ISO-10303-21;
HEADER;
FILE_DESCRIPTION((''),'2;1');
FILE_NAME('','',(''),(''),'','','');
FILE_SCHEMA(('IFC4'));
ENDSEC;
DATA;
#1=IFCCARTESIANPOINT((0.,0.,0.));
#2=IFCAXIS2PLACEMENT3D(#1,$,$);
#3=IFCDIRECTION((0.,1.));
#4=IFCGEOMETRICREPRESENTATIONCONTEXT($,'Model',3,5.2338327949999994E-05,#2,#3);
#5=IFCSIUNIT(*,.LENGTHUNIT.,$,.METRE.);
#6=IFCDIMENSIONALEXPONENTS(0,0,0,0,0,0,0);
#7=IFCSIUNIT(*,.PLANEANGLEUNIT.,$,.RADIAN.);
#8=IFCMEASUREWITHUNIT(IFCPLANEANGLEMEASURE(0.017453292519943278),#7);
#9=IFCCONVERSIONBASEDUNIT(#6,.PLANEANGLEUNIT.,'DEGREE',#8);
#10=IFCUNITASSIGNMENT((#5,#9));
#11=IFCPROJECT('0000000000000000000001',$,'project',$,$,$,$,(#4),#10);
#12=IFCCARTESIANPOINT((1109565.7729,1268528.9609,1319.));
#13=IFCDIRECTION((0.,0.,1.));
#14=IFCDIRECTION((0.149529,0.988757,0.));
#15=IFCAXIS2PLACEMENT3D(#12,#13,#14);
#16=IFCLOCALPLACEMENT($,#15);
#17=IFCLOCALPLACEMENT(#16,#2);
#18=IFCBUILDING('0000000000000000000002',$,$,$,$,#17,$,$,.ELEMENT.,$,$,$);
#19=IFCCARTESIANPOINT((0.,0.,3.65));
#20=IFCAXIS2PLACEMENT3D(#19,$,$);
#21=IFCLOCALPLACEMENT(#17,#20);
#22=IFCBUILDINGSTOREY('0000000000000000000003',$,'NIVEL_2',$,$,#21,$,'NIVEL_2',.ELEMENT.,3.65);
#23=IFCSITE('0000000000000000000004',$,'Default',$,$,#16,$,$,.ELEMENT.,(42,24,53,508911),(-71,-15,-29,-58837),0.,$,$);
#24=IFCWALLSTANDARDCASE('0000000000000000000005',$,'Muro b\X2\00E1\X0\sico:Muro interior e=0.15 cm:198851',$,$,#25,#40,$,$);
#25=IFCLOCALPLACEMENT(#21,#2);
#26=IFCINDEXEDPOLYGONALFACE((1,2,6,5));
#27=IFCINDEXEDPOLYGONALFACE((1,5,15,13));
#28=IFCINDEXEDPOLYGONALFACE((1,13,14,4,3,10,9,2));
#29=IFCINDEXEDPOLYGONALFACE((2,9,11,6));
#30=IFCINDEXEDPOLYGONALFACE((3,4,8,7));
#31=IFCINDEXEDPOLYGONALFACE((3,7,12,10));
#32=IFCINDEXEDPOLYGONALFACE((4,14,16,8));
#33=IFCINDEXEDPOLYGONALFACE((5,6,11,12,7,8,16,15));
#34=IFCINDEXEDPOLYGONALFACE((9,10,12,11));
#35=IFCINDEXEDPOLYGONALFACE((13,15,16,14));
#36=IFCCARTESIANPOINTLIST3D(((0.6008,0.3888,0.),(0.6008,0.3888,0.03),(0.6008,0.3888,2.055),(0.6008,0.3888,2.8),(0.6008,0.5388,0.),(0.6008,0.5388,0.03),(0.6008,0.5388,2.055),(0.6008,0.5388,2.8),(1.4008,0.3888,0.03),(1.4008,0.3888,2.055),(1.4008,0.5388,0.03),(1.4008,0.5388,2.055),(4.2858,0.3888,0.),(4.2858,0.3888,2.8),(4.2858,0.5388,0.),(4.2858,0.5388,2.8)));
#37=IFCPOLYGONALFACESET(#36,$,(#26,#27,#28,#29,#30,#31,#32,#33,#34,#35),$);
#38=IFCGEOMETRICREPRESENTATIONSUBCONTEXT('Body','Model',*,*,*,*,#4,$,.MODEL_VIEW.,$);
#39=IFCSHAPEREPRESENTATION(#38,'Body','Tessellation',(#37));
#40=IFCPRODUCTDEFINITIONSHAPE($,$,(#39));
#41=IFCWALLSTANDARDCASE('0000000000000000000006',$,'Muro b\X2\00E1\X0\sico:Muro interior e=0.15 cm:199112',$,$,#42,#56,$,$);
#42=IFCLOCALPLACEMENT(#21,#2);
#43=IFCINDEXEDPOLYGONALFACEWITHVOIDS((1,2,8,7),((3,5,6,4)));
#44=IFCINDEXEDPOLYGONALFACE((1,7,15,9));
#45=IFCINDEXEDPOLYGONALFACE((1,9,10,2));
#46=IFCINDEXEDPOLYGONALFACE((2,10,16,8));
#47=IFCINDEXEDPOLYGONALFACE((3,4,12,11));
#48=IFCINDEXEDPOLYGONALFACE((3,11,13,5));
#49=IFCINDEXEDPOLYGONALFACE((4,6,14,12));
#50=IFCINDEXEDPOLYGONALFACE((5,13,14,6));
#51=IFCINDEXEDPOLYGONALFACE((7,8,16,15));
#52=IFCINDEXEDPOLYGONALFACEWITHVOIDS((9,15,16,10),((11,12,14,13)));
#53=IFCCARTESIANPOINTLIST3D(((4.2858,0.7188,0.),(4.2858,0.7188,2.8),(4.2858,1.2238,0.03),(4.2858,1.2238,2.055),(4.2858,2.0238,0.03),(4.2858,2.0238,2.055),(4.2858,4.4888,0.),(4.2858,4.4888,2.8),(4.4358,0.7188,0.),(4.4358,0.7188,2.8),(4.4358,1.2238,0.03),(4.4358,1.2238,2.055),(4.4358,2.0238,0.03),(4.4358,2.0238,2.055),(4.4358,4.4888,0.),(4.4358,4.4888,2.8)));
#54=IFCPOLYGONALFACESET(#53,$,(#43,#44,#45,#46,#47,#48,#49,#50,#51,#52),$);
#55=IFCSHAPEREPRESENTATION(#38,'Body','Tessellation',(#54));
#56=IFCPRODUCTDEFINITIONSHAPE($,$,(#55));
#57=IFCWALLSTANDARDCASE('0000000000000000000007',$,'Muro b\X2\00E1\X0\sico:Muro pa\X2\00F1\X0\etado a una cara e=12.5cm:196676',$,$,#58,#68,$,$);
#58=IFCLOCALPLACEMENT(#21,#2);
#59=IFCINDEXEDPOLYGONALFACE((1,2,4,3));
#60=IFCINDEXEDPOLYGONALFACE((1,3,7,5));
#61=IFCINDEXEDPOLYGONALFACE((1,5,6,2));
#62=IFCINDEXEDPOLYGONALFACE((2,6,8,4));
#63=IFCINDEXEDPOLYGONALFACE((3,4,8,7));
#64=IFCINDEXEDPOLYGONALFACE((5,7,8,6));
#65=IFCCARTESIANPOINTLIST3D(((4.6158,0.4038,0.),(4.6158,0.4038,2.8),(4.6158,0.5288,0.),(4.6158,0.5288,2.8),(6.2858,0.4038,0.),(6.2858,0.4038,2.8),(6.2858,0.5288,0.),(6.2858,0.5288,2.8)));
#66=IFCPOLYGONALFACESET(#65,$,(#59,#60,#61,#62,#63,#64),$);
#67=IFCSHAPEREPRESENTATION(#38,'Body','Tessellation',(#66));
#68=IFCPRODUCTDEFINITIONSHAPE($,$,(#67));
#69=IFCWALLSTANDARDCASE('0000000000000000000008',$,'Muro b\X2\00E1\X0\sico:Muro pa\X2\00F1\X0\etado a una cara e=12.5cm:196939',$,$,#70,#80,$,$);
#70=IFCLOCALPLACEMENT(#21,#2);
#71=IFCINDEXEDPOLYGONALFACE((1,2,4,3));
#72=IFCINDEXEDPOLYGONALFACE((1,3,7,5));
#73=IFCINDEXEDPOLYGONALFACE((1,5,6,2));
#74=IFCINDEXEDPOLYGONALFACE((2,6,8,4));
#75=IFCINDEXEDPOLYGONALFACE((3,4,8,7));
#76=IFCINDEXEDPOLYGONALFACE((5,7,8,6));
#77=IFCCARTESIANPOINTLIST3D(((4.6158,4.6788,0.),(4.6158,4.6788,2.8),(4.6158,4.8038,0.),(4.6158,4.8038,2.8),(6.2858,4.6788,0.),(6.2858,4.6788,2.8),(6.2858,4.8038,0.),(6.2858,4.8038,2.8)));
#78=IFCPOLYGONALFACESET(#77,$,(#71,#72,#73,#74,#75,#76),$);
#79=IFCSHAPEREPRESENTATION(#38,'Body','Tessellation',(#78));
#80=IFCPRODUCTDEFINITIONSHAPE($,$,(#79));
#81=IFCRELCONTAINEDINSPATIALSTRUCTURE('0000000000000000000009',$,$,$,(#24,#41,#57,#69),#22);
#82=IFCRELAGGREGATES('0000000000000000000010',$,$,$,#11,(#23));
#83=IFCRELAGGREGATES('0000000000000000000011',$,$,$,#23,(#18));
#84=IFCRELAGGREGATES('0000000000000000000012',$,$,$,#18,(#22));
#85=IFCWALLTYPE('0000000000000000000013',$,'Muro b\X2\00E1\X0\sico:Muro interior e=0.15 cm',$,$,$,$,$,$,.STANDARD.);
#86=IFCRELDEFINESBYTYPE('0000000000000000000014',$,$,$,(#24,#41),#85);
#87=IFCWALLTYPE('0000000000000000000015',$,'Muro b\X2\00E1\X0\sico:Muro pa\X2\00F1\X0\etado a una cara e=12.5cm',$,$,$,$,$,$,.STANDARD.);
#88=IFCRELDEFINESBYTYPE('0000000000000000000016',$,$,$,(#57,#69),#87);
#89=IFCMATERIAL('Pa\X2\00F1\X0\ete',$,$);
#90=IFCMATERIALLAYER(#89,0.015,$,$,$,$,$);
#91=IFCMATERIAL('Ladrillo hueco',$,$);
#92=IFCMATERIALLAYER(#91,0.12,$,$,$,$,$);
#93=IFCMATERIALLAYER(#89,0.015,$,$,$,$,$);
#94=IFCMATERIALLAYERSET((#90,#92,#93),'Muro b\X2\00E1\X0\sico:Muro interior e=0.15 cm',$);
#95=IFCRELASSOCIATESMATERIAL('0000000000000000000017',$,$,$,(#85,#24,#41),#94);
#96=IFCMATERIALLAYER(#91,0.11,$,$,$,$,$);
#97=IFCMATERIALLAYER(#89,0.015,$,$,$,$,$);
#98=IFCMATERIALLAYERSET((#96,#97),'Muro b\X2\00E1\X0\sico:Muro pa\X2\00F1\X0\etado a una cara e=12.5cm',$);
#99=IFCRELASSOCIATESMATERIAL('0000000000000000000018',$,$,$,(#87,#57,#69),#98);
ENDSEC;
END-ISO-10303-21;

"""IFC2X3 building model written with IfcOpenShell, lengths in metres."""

from ifc_helpers import new_model, entity, si_unit, converted_unit, direction, frame, frame_2d, origin, place, context, subcontext, project, spatial, rectangle, extrude, material, layer, layer_set, layer_usage, type_object, element, save


model = new_model("IFC2X3")

# Units and contexts
model_context = context("Model", 3, precision=5.2338327949999994e-05, world=origin(), true_north=direction((0.0, 1.0)))
body_context = subcontext(model_context, "Body", "Model", "MODEL_VIEW")
ifc_project = project(units=[si_unit("LENGTHUNIT", "METRE"), converted_unit("PLANEANGLEUNIT", "DEGREE", entity("IfcPlaneAngleMeasure", 0.017453292519943278), si_unit("PLANEANGLEUNIT", "RADIAN"), dimensions=[0, 0, 0, 0, 0, 0, 0])], contexts=[model_context])

# Site, building, storey
site_placement = place(None, frame((1109565.7729, 1268528.9609, 1319.0), z_axis=(0.0, 0.0, 1.0), x_axis=(0.149529, 0.988757, 0.0)))
site = spatial("IfcSite", under=ifc_project, at=site_placement, Name="Default", CompositionType="ELEMENT", RefLatitude=(42, 24, 53, 508911), RefLongitude=(-71, -15, -29, -58837), RefElevation=0.0)
building_placement = place(site_placement, origin())
building = spatial("IfcBuilding", under=site, at=building_placement, CompositionType="ELEMENT")
storey_placement = place(building_placement, frame((0.0, 0.0, 3.65)))
storey = spatial("IfcBuildingStorey", under=building, at=storey_placement, Name="NIVEL_2", LongName="NIVEL_2", CompositionType="ELEMENT", Elevation=3.65)

# Walls, openings
ifc_material_1 = material(Name="Pañete")
ifc_layer_1 = layer(ifc_material_1, 0.015)
ifc_material_2 = material(Name="Ladrillo hueco")
ifc_layer_2 = layer(ifc_material_2, 0.12)
ifc_layer_3 = layer(ifc_material_1, 0.015)
ifc_layer_set_1 = layer_set([ifc_layer_1, ifc_layer_2, ifc_layer_3], Name="Muro básico:Muro interior e=0.15 cm")
ifc_layer_usage_1 = layer_usage(ifc_layer_set_1, "AXIS2", "NEGATIVE", 0.075)
wall_type_1 = type_object("IfcWallType", Name="Muro básico:Muro interior e=0.15 cm", PredefinedType="STANDARD", material=ifc_layer_set_1)
wall_1_placement = place(storey_placement, frame((4.2858, 0.4638, 0.0), z_axis=(0.0, 0.0, 1.0), x_axis=(-1.0, 0.0, 0.0)))
wall_1 = element("IfcWallStandardCase", 1, at=wall_1_placement, inside=storey, type_object=wall_type_1, material=ifc_layer_usage_1, Name="Muro básico:Muro interior e=0.15 cm:198851", context=body_context, shape_type="SweptSolid", body=[
    extrude(rectangle(XDim=3.685, YDim=0.15, at=frame_2d((1.8425, 0.0), x_axis=(-1.0, 0.0))), origin(), (0.0, 0.0, 1.0), 2.8),
])
opening_1_placement = place(wall_1_placement, frame((3.685, 0.075, 0.03)))
element("IfcOpeningElement", 2, at=opening_1_placement, cuts=wall_1, ObjectType="Opening", context=body_context, shape_type="SweptSolid", body=[
    extrude(rectangle(XDim=2.025, YDim=0.8, at=frame_2d((1.0125, 0.4), x_axis=(1.0, 0.0))), frame((0.0, 0.0, 0.0), z_axis=(0.0, -1.0, 0.0), x_axis=(0.0, 0.0, 1.0)), (0.0, 0.0, 1.0), 0.15),
])
ifc_layer_usage_2 = layer_usage(ifc_layer_set_1, "AXIS2", "NEGATIVE", 0.075)
wall_2_placement = place(storey_placement, frame((4.3608, 0.7188, 0.0), z_axis=(0.0, 0.0, 1.0), x_axis=(0.0, 1.0, 0.0)))
wall_2 = element("IfcWallStandardCase", 3, at=wall_2_placement, inside=storey, type_object=wall_type_1, material=ifc_layer_usage_2, Name="Muro básico:Muro interior e=0.15 cm:199112", context=body_context, shape_type="SweptSolid", body=[
    extrude(rectangle(XDim=3.77, YDim=0.15, at=frame_2d((1.885, 0.0), x_axis=(-1.0, 0.0))), origin(), (0.0, 0.0, 1.0), 2.8),
])
opening_2_placement = place(wall_2_placement, frame((1.305, 0.075, 0.03)))
element("IfcOpeningElement", 4, at=opening_2_placement, cuts=wall_2, ObjectType="Opening", context=body_context, shape_type="SweptSolid", body=[
    extrude(rectangle(XDim=2.025, YDim=0.8, at=frame_2d((1.0125, 0.4), x_axis=(1.0, 0.0))), frame((0.0, 0.0, 0.0), z_axis=(0.0, -1.0, 0.0), x_axis=(0.0, 0.0, 1.0)), (0.0, 0.0, 1.0), 0.15),
])

# Wall
ifc_layer_4 = layer(ifc_material_2, 0.11)
ifc_layer_5 = layer(ifc_material_1, 0.015)
ifc_layer_set_2 = layer_set([ifc_layer_4, ifc_layer_5], Name="Muro básico:Muro pañetado a una cara e=12.5cm")
ifc_layer_usage_3 = layer_usage(ifc_layer_set_2, "AXIS2", "POSITIVE", -0.0625)
wall_type_2 = type_object("IfcWallType", Name="Muro básico:Muro pañetado a una cara e=12.5cm", PredefinedType="STANDARD", material=ifc_layer_set_2)
wall_3_placement = place(storey_placement, frame((4.6158, 0.4663, 0.0)))
element("IfcWallStandardCase", 5, at=wall_3_placement, inside=storey, type_object=wall_type_2, material=ifc_layer_usage_3, Name="Muro básico:Muro pañetado a una cara e=12.5cm:196676", context=body_context, shape_type="SweptSolid", body=[
    extrude(rectangle(XDim=1.67, YDim=0.125, at=frame_2d((0.835, 0.0), x_axis=(-1.0, 0.0))), origin(), (0.0, 0.0, 1.0), 2.8),
])

# Wall
ifc_layer_usage_4 = layer_usage(ifc_layer_set_2, "AXIS2", "POSITIVE", -0.0625)
wall_4_placement = place(storey_placement, frame((6.2858, 4.7413, 0.0), z_axis=(0.0, 0.0, 1.0), x_axis=(-1.0, 0.0, 0.0)))
element("IfcWallStandardCase", 6, at=wall_4_placement, inside=storey, type_object=wall_type_2, material=ifc_layer_usage_4, Name="Muro básico:Muro pañetado a una cara e=12.5cm:196939", context=body_context, shape_type="SweptSolid", body=[
    extrude(rectangle(XDim=1.67, YDim=0.125, at=frame_2d((0.835, 0.0), x_axis=(-1.0, 0.0))), origin(), (0.0, 0.0, 1.0), 2.8),
])

save(model, "model.ifc")
